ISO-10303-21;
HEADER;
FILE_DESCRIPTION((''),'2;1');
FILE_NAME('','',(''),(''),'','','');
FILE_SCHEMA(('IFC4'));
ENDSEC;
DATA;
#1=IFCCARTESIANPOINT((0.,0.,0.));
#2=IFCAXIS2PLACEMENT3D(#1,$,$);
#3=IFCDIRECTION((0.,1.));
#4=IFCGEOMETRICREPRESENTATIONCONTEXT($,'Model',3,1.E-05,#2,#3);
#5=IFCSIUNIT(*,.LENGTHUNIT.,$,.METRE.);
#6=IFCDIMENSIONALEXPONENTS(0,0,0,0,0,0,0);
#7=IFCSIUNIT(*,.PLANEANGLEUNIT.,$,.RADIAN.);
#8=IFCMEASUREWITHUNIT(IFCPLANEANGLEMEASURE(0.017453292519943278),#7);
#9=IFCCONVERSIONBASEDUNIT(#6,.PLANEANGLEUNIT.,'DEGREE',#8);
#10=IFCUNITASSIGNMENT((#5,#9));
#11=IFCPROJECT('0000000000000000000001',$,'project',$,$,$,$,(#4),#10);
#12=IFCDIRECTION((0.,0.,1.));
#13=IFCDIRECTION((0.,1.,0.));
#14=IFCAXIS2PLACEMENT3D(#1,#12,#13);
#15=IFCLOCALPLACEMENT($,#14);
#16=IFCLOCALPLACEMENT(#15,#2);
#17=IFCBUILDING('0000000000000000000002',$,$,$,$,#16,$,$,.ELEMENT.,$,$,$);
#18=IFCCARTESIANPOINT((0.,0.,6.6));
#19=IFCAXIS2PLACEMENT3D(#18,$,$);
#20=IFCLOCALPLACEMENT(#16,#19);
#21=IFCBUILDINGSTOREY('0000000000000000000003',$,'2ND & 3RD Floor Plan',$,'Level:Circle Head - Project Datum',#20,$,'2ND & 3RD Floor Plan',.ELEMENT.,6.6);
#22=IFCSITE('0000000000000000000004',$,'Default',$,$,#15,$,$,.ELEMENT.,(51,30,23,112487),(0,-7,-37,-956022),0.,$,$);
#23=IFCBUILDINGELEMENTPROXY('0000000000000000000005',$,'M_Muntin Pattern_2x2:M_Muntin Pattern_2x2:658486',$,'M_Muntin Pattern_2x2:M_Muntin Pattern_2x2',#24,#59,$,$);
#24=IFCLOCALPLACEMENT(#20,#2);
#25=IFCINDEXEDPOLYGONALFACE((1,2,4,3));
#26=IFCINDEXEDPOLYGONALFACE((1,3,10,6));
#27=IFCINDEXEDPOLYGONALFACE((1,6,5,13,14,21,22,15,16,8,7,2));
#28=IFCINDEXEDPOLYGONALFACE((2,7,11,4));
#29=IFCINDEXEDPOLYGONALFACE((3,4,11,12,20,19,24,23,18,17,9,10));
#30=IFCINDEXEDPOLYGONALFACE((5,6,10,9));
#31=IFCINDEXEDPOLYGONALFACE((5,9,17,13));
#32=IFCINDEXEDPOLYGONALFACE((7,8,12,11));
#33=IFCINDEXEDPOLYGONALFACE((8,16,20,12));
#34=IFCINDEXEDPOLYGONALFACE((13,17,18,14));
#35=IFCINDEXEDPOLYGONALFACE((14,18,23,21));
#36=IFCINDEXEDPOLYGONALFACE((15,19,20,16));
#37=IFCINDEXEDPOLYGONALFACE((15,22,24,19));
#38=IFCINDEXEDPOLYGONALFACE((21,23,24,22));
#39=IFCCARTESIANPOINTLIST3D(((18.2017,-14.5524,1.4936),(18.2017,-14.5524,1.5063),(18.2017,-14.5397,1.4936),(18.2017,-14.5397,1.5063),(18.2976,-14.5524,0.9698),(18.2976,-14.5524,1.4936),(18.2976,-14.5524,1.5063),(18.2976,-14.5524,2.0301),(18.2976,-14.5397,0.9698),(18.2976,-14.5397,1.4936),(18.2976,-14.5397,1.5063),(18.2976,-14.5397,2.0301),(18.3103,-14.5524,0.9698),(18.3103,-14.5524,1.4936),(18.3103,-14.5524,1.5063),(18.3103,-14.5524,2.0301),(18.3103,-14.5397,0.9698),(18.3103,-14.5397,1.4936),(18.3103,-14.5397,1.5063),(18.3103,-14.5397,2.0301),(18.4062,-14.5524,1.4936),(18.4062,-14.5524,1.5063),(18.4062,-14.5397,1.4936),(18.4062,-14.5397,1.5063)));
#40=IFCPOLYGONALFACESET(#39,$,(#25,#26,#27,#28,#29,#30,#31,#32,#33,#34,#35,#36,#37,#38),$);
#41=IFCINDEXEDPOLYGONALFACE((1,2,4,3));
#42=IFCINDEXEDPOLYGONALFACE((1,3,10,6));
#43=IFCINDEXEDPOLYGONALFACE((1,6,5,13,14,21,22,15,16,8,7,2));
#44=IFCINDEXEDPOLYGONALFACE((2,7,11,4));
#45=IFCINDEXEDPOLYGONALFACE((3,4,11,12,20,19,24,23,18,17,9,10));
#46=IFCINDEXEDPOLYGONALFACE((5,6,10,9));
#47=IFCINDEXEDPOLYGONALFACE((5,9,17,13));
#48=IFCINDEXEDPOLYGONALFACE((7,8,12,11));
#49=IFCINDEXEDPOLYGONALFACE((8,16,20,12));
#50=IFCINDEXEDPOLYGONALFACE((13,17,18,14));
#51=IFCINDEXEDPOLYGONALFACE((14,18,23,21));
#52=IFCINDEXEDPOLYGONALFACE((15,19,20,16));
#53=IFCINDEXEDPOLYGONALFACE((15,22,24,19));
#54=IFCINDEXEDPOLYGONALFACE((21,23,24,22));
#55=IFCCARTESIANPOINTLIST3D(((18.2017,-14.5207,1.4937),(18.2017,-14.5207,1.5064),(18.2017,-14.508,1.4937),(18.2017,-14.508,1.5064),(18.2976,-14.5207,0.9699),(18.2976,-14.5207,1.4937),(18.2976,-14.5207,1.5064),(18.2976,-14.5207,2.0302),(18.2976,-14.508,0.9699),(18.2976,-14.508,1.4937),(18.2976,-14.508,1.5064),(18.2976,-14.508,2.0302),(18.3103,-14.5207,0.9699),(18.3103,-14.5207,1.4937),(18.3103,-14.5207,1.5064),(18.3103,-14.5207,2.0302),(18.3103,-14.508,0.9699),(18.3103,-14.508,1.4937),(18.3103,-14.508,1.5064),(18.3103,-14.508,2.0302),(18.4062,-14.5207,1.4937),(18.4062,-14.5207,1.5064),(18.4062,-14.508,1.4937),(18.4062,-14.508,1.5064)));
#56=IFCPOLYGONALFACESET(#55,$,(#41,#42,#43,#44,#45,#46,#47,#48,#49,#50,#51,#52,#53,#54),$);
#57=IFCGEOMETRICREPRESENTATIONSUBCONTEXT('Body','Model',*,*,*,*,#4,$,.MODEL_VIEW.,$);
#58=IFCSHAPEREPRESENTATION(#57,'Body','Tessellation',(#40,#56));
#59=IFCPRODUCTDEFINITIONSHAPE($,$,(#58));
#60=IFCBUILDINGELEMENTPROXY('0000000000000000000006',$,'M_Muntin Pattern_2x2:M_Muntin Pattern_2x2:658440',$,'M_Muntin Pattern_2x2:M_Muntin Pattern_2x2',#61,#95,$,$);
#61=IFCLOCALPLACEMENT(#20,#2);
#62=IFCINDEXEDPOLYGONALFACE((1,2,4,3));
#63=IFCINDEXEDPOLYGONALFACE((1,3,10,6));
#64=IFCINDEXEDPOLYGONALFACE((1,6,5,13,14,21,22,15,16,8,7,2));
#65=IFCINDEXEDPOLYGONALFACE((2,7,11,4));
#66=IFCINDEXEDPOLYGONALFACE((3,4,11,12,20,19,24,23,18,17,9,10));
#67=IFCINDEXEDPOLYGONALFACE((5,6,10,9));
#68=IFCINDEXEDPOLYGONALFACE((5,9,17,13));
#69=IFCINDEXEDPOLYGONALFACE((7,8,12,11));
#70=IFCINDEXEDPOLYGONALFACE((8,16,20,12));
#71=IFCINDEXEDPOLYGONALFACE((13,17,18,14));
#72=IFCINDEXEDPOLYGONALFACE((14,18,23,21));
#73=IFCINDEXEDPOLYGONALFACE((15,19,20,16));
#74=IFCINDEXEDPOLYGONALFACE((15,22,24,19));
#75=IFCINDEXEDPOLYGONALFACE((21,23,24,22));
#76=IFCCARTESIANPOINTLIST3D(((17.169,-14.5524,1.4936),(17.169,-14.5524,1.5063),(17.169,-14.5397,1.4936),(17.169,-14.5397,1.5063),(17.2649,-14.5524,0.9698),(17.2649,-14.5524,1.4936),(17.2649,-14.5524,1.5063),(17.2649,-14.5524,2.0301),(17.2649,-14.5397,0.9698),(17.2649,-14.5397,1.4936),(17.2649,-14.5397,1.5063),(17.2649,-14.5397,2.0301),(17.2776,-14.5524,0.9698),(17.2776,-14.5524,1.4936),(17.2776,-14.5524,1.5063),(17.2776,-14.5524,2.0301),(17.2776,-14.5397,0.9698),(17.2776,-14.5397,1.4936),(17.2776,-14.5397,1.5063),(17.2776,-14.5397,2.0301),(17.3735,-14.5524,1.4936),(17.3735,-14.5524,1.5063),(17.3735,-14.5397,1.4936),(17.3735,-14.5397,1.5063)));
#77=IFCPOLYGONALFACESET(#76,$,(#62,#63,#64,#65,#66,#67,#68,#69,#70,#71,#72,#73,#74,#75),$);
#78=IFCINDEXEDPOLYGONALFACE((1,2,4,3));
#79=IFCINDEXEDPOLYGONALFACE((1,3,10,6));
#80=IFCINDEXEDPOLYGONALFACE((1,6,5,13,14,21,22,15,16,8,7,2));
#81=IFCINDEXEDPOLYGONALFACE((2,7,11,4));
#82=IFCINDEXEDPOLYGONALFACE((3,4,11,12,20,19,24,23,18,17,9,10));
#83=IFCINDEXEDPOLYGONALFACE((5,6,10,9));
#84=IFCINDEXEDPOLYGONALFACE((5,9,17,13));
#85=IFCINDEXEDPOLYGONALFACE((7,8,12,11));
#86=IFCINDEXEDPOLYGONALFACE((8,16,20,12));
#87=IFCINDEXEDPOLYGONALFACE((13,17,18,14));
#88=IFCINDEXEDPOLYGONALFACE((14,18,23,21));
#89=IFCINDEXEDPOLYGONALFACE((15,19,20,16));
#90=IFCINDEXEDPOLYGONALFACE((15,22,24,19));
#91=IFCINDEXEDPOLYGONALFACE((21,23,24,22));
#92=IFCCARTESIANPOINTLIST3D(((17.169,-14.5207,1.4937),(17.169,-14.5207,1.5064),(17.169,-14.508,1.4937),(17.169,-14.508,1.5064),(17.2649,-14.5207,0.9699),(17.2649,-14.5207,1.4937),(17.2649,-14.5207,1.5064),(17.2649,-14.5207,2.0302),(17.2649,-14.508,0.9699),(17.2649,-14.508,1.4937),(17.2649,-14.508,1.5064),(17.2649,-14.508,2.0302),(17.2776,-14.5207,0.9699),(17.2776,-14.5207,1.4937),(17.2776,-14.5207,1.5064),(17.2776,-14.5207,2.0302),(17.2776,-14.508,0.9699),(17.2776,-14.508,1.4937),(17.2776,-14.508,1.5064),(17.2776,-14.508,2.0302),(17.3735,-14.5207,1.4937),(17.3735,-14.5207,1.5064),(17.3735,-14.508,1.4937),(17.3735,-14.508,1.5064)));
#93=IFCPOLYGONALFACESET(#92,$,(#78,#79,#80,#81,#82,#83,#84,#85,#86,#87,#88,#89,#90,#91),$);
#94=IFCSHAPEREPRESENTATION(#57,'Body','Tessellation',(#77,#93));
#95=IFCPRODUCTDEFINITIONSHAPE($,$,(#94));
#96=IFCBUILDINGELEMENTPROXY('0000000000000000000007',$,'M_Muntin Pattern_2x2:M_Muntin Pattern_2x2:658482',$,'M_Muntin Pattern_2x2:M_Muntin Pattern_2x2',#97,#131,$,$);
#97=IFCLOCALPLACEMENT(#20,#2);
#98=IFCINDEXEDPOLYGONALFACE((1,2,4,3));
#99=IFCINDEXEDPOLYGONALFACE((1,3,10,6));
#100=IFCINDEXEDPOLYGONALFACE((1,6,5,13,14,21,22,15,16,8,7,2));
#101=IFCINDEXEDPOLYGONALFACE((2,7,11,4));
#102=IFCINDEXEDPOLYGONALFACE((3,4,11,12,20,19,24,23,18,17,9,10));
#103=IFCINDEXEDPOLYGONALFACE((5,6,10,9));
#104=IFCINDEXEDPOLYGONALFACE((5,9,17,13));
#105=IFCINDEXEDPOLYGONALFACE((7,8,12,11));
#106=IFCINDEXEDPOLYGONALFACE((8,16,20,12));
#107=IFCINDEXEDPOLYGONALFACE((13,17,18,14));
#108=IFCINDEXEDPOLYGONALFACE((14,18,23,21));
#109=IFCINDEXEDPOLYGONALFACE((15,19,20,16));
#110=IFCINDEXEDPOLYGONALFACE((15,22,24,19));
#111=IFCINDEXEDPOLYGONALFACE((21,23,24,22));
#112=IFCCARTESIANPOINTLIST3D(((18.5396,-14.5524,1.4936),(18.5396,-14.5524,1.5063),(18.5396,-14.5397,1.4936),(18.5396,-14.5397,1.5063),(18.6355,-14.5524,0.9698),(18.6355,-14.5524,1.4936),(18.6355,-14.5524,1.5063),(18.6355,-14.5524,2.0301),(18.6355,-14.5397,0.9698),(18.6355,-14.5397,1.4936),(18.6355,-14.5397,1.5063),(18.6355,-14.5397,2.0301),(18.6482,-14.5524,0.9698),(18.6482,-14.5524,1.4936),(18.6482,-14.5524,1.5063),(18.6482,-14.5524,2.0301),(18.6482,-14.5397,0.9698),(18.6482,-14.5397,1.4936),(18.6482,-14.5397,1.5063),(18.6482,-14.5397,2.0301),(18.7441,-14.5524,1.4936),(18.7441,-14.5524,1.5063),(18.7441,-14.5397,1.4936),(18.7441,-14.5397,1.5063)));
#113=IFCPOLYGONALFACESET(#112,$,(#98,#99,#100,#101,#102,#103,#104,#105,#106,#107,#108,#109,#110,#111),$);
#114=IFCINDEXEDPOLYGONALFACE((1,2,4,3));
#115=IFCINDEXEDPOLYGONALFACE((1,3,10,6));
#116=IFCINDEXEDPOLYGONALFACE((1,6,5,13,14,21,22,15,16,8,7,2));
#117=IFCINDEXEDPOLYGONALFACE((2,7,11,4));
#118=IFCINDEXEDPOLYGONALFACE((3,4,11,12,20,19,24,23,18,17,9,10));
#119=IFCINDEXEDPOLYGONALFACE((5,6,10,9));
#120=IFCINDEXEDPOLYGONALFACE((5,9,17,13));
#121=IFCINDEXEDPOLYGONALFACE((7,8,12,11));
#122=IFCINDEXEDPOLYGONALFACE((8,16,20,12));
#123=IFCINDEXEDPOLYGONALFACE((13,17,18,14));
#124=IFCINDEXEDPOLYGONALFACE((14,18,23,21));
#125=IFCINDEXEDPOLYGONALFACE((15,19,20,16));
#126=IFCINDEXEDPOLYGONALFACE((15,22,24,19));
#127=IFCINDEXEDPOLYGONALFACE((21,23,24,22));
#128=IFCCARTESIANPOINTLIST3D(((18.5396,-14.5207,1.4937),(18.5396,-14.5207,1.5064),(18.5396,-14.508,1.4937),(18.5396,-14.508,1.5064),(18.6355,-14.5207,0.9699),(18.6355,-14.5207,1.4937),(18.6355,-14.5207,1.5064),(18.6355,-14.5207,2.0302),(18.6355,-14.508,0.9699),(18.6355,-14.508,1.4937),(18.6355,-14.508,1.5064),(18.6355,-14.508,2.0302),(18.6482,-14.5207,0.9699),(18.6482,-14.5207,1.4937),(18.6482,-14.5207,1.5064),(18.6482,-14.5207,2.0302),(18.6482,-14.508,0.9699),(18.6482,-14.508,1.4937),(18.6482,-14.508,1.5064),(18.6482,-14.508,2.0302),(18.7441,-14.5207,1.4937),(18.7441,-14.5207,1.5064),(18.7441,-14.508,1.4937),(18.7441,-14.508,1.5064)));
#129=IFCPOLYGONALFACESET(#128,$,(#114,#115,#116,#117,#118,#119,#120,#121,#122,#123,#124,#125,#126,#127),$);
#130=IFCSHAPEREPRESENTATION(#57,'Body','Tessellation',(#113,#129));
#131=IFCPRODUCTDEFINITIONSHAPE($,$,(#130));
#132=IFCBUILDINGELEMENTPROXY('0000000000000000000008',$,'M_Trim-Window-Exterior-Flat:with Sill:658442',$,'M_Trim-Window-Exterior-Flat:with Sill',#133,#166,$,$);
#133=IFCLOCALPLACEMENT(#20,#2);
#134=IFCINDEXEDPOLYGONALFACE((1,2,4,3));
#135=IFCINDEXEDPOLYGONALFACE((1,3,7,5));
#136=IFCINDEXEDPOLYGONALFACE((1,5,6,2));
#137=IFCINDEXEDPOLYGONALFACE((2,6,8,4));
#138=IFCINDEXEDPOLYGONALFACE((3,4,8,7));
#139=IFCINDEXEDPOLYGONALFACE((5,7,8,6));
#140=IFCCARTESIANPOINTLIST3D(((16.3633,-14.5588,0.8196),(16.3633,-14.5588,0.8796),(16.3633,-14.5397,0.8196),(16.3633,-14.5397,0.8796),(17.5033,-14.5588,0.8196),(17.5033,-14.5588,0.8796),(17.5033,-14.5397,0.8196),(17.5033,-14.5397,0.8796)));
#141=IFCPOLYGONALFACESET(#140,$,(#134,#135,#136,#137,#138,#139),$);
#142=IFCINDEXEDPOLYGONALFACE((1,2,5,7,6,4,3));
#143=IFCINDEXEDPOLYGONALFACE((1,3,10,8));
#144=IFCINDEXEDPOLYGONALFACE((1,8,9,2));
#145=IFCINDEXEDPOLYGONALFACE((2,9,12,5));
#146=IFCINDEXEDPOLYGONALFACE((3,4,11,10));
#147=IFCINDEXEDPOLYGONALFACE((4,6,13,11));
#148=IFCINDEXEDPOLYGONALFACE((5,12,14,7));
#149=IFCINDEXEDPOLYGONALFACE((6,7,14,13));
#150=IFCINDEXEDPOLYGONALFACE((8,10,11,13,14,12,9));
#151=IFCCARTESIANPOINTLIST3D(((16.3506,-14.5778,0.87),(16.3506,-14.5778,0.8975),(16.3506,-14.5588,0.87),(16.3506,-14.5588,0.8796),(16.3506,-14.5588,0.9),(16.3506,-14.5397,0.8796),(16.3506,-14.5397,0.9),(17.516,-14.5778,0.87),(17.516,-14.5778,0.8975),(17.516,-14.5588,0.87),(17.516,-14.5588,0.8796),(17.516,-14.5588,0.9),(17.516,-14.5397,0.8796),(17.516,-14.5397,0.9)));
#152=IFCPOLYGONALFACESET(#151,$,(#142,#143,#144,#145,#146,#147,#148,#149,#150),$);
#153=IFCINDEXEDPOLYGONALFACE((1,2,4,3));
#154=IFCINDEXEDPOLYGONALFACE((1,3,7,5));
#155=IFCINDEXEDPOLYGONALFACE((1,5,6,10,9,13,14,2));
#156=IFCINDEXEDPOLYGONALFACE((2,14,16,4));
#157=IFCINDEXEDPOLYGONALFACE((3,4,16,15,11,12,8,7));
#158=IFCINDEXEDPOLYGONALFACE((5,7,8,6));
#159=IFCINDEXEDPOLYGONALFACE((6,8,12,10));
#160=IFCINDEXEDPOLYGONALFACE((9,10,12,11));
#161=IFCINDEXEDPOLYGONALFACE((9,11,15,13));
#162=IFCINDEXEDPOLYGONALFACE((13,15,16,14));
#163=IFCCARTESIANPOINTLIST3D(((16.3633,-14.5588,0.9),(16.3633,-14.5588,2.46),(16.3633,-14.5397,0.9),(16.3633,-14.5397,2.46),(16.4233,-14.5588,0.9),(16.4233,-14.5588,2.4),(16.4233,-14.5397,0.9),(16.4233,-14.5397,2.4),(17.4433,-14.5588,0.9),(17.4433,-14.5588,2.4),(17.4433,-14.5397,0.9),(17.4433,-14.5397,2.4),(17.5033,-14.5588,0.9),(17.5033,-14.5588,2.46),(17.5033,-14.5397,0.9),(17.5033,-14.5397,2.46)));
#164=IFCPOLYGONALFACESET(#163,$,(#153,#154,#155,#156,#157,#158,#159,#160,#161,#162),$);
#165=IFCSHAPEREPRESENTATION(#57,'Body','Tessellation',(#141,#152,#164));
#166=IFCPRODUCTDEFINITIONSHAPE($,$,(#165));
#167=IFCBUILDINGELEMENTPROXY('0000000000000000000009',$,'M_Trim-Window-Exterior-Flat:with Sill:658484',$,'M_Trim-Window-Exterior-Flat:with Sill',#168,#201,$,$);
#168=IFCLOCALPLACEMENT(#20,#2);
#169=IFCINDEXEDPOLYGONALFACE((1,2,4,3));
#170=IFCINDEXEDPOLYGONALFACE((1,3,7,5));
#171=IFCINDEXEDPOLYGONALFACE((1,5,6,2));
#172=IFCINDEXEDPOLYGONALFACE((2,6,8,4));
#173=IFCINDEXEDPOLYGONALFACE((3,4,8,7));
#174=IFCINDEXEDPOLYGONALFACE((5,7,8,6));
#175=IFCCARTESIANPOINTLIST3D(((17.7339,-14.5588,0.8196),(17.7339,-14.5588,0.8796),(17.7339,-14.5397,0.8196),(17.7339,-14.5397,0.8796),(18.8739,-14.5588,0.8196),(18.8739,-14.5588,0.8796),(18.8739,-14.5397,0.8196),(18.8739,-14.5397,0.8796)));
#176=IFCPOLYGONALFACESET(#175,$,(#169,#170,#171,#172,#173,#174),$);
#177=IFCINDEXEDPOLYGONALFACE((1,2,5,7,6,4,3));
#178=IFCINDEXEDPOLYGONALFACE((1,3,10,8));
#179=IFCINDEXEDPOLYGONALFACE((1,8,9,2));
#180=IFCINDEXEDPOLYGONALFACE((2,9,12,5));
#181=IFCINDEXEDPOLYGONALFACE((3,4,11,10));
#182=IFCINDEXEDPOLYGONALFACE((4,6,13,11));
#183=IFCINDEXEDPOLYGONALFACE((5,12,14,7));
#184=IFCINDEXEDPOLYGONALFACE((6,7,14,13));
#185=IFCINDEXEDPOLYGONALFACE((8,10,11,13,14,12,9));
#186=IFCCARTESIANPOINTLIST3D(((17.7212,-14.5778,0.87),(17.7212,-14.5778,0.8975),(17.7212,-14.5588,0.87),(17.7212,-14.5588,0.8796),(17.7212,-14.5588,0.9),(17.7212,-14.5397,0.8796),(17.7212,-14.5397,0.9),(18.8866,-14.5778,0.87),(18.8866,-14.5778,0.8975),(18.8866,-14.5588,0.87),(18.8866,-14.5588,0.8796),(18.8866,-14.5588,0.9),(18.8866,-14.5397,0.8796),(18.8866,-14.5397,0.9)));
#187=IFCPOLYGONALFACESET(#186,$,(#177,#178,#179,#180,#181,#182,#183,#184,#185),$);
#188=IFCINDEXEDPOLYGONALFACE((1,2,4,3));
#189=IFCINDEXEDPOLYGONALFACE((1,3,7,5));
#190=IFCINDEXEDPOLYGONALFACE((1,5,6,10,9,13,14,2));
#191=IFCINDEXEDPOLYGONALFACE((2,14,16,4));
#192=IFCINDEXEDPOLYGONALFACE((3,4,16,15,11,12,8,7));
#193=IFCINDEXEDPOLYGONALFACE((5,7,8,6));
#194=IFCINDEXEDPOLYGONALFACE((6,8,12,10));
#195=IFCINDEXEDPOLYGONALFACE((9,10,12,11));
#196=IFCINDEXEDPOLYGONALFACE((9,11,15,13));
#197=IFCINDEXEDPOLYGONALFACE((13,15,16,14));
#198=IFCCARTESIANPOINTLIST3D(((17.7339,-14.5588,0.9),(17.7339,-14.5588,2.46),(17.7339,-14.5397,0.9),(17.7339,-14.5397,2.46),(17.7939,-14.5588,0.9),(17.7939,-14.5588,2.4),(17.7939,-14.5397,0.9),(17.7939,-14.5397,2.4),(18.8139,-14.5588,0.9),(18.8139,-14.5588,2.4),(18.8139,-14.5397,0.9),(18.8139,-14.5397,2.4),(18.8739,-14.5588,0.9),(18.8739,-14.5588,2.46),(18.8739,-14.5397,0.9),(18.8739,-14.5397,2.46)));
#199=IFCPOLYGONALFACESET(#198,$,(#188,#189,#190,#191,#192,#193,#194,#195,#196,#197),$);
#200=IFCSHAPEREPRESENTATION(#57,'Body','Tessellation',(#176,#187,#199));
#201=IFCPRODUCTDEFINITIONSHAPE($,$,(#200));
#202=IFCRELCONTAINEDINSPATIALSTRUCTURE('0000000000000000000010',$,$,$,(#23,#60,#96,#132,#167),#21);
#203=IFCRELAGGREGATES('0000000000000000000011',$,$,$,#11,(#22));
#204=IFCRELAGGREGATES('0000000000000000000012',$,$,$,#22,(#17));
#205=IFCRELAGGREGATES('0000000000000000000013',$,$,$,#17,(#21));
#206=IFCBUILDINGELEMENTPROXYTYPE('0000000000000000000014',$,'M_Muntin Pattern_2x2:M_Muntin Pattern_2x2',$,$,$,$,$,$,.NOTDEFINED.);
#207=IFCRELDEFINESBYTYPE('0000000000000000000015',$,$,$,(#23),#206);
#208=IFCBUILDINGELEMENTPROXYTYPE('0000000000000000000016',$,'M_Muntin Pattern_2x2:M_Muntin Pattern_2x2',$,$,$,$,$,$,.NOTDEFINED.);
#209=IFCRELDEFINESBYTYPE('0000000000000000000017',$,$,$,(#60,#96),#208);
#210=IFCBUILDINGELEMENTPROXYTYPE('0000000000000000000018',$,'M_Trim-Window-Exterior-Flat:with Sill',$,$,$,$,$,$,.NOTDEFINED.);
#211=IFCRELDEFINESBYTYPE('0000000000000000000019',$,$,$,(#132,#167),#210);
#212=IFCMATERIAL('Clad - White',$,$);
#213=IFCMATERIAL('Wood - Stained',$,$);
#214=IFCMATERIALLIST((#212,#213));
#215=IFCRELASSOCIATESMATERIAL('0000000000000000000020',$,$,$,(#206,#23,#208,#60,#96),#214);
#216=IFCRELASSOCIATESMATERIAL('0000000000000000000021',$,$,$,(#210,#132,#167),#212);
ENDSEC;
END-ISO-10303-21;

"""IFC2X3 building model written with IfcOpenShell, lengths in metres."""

from ifc_helpers import new_model, entity, si_unit, converted_unit, direction, frame, frame_2d, origin, place, context, subcontext, project, spatial, polyline, rectangle, outline, extrude, source, transform, mapped, material, material_list, type_object, type_shapes, element, save


model = new_model("IFC2X3")

# Units and contexts
model_context = context("Model", 3, precision=1e-05, world=origin(), true_north=direction((0.0, 1.0)))
body_context = subcontext(model_context, "Body", "Model", "MODEL_VIEW")
ifc_project = project(units=[si_unit("LENGTHUNIT", "METRE"), converted_unit("PLANEANGLEUNIT", "DEGREE", entity("IfcPlaneAngleMeasure", 0.017453292519943278), si_unit("PLANEANGLEUNIT", "RADIAN"), dimensions=[0, 0, 0, 0, 0, 0, 0])], contexts=[model_context])

# Site, building, storey
site_placement = place(None, frame((0.0, 0.0, 0.0), z_axis=(0.0, 0.0, 1.0), x_axis=(0.0, 1.0, 0.0)))
site = spatial("IfcSite", under=ifc_project, at=site_placement, Name="Default", CompositionType="ELEMENT", RefLatitude=(51, 30, 23, 112487), RefLongitude=(0, -7, -37, -956022), RefElevation=0.0)
building_placement = place(site_placement, origin())
building = spatial("IfcBuilding", under=site, at=building_placement, CompositionType="ELEMENT")
storey_placement = place(building_placement, frame((0.0, 0.0, 6.6)))
storey = spatial("IfcBuildingStorey", under=building, at=storey_placement, Name="2ND & 3RD Floor Plan", ObjectType="Level:Circle Head - Project Datum", LongName="2ND & 3RD Floor Plan", CompositionType="ELEMENT", Elevation=6.6)

# Building element proxies
ifc_material_1 = material(Name="Clad - White")
ifc_material_2 = material(Name="Wood - Stained")
ifc_material_list = material_list([ifc_material_1, ifc_material_2])
building_element_proxy_type_1 = type_object("IfcBuildingElementProxyType", Name="M_Muntin Pattern_2x2:M_Muntin Pattern_2x2", PredefinedType="NOTDEFINED", material=ifc_material_list)
shared_shape_1 = source(origin(), body_context, "Body", "SweptSolid", [
    extrude(outline(polyline([(0.0064, -0.0064), (0.5301, -0.0064), (0.5301, 0.0063), (0.0064, 0.0063), (0.0064, 0.1023), (-0.0063, 0.1023), (-0.0063, 0.0063), (-0.5302, 0.0063), (-0.5302, -0.0064), (-0.0063, -0.0064), (-0.0063, -0.1023), (0.0064, -0.1023), (0.0064, -0.0064)])), frame((0.0, -0.0222, 0.5301), z_axis=(0.0, 1.0, 0.0), x_axis=(0.0, 0.0, 1.0)), (0.0, 0.0, 1.0), 0.0127),
    extrude(outline(polyline([(0.0064, -0.0064), (0.5302, -0.0064), (0.5302, 0.0063), (0.0064, 0.0063), (0.0064, 0.1023), (-0.0063, 0.1023), (-0.0063, 0.0063), (-0.5302, 0.0063), (-0.5302, -0.0064), (-0.0063, -0.0064), (-0.0063, -0.1023), (0.0064, -0.1023), (0.0064, -0.0064)])), frame((0.0, 0.0095, 0.5302), z_axis=(0.0, 1.0, 0.0), x_axis=(0.0, 0.0, 1.0)), (0.0, 0.0, 1.0), 0.0127),
])
type_shapes(building_element_proxy_type_1, [shared_shape_1])
for number, where, name in (
    (1, (18.3039, -14.5302, 0.9699), "M_Muntin Pattern_2x2:M_Muntin Pattern_2x2:658486"),
):
    element("IfcBuildingElementProxy", number, at=place(storey_placement, frame(where)), inside=storey, type_object=building_element_proxy_type_1, material=ifc_material_list, Name=name, ObjectType="M_Muntin Pattern_2x2:M_Muntin Pattern_2x2", context=body_context, shape_type="MappedRepresentation", body=[
        mapped(shared_shape_1, transform((0.0, 0.0, 0.0), scale=1.0)),
    ])
building_element_proxy_type_2 = type_object("IfcBuildingElementProxyType", Name="M_Muntin Pattern_2x2:M_Muntin Pattern_2x2", PredefinedType="NOTDEFINED", material=ifc_material_list)
shared_shape_2 = source(origin(), body_context, "Body", "SweptSolid", [
    extrude(outline(polyline([(0.0064, -0.0064), (0.5301, -0.0064), (0.5301, 0.0063), (0.0064, 0.0063), (0.0064, 0.1023), (-0.0063, 0.1023), (-0.0063, 0.0063), (-0.5302, 0.0063), (-0.5302, -0.0064), (-0.0063, -0.0064), (-0.0063, -0.1023), (0.0064, -0.1023), (0.0064, -0.0064)])), frame((0.0, 0.0095, 0.5301), z_axis=(0.0, 1.0, 0.0), x_axis=(0.0, 0.0, 1.0)), (0.0, 0.0, 1.0), 0.0127),
    extrude(outline(polyline([(0.0064, -0.0064), (0.5302, -0.0064), (0.5302, 0.0063), (0.0064, 0.0063), (0.0064, 0.1023), (-0.0063, 0.1023), (-0.0063, 0.0063), (-0.5302, 0.0063), (-0.5302, -0.0064), (-0.0063, -0.0064), (-0.0063, -0.1023), (0.0064, -0.1023), (0.0064, -0.0064)])), frame((0.0, -0.0222, 0.5302), z_axis=(0.0, 1.0, 0.0), x_axis=(0.0, 0.0, 1.0)), (0.0, 0.0, 1.0), 0.0127),
])
type_shapes(building_element_proxy_type_2, [shared_shape_2])
for number, where, z_axis, x_axis, name in (
    (2, (17.2712, -14.5302, 0.9699), (0.0, 0.0, 1.0), (-1.0, 0.0, 0.0), "M_Muntin Pattern_2x2:M_Muntin Pattern_2x2:658440"),
    (3, (18.6418, -14.5302, 0.9699), (0.0, 0.0, 1.0), (-1.0, 0.0, 0.0), "M_Muntin Pattern_2x2:M_Muntin Pattern_2x2:658482"),
):
    element("IfcBuildingElementProxy", number, at=place(storey_placement, frame(where, z_axis=z_axis, x_axis=x_axis)), inside=storey, type_object=building_element_proxy_type_2, material=ifc_material_list, Name=name, ObjectType="M_Muntin Pattern_2x2:M_Muntin Pattern_2x2", context=body_context, shape_type="MappedRepresentation", body=[
        mapped(shared_shape_2, transform((0.0, 0.0, 0.0), scale=1.0)),
    ])
building_element_proxy_type_3 = type_object("IfcBuildingElementProxyType", Name="M_Trim-Window-Exterior-Flat:with Sill", PredefinedType="NOTDEFINED", material=ifc_material_1)
shared_shape_3 = source(origin(), body_context, "Body", "SweptSolid", [
    extrude(rectangle(XDim=1.14, YDim=0.06, at=frame_2d((0.0, 0.0), x_axis=(1.0, 0.0))), frame((0.0, -1.5504, 0.0), z_axis=(0.0, 0.0, 1.0), x_axis=(-1.0, 0.0, 0.0)), (0.0, 0.0, 1.0), 0.019),
    extrude(outline(polyline([(-0.019, -0.0152), (0.0, -0.0152), (0.0, -0.0057), (0.019, -0.0057), (0.019, 0.0148), (0.0, 0.0148), (-0.019, 0.0123), (-0.019, -0.0152)])), frame((-0.5827, -1.5148, 0.019), z_axis=(1.0, 0.0, 0.0), x_axis=(0.0, 0.0, -1.0)), (0.0, 0.0, 1.0), 1.1654),
    extrude(outline(polyline([(-0.795, -0.57), (0.765, -0.57), (0.765, -0.51), (-0.735, -0.51), (-0.735, 0.51), (0.765, 0.51), (0.765, 0.57), (-0.795, 0.57), (-0.795, -0.57)])), frame((0.0, -0.735, 0.0), z_axis=(0.0, 0.0, 1.0), x_axis=(0.0, -1.0, 0.0)), (0.0, 0.0, 1.0), 0.019),
])
type_shapes(building_element_proxy_type_3, [shared_shape_3])
for number, where, z_axis, x_axis, name in (
    (4, (16.9333, -14.5397, 2.4), (0.0, -1.0, 0.0), (1.0, 0.0, 0.0), "M_Trim-Window-Exterior-Flat:with Sill:658442"),
    (5, (18.3039, -14.5397, 2.4), (0.0, -1.0, 0.0), (1.0, 0.0, 0.0), "M_Trim-Window-Exterior-Flat:with Sill:658484"),
):
    element("IfcBuildingElementProxy", number, at=place(storey_placement, frame(where, z_axis=z_axis, x_axis=x_axis)), inside=storey, type_object=building_element_proxy_type_3, material=ifc_material_1, Name=name, ObjectType="M_Trim-Window-Exterior-Flat:with Sill", context=body_context, shape_type="MappedRepresentation", body=[
        mapped(shared_shape_3, transform((0.0, 0.0, 0.0), scale=1.0)),
    ])

save(model, "model.ifc")
